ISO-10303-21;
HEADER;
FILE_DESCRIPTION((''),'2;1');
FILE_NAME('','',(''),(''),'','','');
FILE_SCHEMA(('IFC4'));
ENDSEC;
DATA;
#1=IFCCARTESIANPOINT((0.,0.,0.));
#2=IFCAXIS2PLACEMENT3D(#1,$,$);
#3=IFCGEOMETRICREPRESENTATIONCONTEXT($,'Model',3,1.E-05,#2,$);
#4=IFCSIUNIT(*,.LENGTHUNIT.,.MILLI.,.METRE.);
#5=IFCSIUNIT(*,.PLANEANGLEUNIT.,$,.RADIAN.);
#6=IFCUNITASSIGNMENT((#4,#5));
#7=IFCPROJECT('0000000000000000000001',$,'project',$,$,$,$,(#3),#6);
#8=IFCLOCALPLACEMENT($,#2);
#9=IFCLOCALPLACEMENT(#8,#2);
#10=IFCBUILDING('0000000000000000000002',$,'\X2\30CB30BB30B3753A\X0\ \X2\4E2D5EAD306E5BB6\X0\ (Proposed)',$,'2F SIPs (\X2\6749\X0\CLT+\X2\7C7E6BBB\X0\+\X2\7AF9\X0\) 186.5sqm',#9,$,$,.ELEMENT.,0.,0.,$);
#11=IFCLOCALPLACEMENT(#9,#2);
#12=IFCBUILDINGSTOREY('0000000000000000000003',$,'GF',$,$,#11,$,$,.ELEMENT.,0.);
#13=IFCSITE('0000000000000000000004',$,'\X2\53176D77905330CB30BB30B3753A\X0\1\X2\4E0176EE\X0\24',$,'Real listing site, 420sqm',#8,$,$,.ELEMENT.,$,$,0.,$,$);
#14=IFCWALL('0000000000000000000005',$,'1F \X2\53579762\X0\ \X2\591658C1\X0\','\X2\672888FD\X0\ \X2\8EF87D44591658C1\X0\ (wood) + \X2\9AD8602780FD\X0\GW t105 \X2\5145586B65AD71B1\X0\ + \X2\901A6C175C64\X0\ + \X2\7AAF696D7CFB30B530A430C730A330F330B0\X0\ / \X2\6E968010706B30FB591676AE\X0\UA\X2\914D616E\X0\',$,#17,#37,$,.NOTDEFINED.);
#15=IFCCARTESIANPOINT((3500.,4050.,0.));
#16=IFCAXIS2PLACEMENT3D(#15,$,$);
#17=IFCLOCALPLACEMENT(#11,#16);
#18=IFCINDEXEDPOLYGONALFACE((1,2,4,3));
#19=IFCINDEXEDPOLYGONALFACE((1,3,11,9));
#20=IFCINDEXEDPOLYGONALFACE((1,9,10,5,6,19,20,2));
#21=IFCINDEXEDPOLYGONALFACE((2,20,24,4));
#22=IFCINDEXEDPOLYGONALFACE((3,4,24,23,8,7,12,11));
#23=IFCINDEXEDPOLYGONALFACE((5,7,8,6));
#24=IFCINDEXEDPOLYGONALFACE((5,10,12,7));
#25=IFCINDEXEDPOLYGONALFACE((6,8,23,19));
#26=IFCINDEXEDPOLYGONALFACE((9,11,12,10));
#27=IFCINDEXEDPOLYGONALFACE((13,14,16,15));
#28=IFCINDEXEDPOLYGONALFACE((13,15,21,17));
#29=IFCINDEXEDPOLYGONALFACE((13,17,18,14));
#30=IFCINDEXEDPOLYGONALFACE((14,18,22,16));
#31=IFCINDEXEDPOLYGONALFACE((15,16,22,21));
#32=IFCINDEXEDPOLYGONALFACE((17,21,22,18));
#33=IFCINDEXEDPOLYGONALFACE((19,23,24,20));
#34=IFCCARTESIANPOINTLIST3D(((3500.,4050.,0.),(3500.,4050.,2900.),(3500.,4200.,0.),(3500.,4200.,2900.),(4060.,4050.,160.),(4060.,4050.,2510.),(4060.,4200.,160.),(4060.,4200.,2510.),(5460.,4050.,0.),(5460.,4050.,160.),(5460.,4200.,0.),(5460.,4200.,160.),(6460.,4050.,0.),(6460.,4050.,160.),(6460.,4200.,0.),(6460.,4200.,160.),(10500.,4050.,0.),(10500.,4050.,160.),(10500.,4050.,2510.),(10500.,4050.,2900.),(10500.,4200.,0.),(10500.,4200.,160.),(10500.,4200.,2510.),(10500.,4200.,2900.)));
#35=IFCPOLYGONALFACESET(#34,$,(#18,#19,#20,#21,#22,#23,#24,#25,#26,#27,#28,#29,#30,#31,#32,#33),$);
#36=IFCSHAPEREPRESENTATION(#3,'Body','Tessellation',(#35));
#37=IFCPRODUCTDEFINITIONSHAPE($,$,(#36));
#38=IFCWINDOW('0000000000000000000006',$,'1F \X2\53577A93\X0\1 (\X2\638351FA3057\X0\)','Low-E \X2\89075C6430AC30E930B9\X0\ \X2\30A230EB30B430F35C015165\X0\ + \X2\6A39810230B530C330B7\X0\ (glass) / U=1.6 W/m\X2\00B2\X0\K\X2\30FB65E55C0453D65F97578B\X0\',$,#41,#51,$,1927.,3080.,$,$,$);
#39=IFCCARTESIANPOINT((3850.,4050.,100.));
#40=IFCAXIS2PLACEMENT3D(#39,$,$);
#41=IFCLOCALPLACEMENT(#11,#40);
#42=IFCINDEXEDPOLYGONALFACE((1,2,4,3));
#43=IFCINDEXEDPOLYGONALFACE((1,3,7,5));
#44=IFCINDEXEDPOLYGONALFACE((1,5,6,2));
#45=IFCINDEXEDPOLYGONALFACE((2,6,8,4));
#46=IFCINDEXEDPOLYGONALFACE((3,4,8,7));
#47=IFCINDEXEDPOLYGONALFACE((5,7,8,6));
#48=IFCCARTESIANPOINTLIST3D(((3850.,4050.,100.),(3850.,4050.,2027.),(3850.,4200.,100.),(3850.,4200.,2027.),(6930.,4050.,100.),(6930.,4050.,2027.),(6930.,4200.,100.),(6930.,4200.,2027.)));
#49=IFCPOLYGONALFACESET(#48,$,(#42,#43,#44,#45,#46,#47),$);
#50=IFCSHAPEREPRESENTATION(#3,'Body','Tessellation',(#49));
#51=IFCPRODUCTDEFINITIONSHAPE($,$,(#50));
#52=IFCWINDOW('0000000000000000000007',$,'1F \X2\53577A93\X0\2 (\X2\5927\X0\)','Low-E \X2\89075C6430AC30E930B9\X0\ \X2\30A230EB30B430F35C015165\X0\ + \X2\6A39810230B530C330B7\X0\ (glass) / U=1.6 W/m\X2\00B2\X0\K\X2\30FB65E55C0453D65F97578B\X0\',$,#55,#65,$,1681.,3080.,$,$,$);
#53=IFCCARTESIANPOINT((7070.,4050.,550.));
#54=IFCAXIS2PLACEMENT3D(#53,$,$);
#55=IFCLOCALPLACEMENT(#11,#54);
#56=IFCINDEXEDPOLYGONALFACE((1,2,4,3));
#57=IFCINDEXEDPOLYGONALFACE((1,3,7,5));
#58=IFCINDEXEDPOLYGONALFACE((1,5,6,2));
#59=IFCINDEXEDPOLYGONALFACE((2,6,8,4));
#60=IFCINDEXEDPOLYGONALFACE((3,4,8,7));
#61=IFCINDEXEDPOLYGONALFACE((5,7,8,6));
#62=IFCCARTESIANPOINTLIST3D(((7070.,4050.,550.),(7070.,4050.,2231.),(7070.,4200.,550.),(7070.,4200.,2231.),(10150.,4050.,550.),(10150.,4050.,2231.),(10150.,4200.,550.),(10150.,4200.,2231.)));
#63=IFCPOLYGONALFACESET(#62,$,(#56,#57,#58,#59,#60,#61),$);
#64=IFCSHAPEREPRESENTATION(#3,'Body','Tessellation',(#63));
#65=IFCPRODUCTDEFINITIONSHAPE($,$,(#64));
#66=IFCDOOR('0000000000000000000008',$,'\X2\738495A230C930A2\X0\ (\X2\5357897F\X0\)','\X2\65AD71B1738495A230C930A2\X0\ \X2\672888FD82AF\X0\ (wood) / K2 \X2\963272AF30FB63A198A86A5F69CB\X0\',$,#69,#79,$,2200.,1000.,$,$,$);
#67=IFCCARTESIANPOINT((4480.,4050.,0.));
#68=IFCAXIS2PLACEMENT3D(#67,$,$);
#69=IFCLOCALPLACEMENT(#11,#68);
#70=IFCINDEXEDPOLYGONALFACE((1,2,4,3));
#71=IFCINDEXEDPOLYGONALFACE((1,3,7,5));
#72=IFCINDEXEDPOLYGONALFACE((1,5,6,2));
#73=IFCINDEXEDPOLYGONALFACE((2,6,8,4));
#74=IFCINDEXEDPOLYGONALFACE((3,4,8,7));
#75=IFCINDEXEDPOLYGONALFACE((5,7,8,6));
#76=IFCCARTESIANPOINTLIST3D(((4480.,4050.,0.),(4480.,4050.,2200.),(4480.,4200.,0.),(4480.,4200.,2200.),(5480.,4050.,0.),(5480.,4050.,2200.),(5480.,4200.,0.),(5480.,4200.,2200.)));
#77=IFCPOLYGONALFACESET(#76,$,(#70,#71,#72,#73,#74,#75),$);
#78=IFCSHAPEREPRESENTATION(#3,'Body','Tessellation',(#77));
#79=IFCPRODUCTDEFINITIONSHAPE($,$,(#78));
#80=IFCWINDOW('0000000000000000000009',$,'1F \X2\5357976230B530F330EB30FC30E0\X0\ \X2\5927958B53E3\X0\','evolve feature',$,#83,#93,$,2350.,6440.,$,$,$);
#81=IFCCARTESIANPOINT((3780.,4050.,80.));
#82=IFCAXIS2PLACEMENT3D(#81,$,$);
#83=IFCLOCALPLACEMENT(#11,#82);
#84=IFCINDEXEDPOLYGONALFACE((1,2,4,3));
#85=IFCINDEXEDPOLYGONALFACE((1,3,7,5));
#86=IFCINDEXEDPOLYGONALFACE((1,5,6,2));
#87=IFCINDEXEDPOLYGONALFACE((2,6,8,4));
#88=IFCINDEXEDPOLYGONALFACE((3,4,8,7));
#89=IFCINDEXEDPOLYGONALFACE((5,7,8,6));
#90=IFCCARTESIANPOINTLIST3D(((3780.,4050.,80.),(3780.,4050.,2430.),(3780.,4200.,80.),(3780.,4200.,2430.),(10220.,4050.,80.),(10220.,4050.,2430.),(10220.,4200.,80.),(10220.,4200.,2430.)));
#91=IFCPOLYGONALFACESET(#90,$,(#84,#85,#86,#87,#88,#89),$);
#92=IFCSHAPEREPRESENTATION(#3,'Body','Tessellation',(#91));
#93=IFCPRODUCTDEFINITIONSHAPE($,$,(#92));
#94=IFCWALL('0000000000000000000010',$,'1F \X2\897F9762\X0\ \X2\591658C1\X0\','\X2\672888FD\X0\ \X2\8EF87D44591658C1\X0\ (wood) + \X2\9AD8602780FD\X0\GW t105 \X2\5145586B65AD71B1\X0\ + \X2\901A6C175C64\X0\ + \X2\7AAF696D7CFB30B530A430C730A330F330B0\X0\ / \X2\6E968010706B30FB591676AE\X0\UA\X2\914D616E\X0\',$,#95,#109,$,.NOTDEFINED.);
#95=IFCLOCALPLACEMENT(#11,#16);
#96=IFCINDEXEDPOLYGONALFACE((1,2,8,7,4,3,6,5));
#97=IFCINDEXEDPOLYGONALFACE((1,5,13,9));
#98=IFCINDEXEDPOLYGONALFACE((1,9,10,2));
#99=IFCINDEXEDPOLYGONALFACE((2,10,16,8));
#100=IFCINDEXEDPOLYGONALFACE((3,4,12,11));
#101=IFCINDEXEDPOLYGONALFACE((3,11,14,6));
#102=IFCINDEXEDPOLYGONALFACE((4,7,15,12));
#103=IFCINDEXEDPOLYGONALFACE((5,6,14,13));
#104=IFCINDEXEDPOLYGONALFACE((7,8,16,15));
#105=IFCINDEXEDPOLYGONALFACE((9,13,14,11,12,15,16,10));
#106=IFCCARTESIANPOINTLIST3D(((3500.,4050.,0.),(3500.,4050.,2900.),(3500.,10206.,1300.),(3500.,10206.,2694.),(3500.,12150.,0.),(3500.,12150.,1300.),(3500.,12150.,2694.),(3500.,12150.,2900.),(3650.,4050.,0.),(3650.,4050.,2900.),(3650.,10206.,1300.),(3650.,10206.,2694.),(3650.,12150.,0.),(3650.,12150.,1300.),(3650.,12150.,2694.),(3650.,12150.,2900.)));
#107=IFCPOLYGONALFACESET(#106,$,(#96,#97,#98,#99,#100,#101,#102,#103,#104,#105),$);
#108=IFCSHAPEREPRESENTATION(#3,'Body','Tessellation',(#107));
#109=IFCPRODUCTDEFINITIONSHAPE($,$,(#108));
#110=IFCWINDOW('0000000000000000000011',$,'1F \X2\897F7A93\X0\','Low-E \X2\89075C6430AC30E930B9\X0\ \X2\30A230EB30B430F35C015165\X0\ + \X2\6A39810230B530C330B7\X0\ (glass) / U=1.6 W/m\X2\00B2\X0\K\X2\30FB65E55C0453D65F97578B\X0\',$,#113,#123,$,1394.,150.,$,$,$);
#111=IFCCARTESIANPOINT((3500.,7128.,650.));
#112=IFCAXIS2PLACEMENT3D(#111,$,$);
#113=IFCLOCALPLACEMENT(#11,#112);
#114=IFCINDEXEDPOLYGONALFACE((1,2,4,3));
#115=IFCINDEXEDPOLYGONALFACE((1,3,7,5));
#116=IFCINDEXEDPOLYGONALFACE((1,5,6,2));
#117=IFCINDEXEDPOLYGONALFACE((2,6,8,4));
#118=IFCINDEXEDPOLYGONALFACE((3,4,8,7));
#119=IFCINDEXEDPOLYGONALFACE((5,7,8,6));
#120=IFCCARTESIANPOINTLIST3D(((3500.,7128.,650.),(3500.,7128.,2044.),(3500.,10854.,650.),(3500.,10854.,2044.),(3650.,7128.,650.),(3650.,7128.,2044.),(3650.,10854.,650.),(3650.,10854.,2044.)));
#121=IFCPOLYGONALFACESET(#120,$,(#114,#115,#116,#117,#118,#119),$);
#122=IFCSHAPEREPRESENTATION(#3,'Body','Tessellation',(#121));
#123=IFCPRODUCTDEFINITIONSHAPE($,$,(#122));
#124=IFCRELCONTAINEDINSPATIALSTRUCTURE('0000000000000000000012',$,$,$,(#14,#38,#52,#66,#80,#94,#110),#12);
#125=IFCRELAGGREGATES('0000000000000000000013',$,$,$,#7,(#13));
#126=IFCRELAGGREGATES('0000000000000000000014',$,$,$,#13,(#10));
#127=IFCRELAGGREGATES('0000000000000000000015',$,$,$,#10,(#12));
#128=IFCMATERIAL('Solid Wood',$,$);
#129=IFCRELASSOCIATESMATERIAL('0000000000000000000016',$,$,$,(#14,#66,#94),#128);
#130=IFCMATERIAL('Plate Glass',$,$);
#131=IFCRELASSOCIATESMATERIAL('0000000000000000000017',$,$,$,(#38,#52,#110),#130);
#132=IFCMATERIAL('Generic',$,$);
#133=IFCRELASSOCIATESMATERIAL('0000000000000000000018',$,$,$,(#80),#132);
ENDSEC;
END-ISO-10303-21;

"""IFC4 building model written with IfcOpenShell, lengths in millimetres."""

from ifc_helpers import new_model, si_unit, frame, frame_2d, origin, place, context, project, spatial, rectangle, extrude, material, element, fill, save


model = new_model("IFC4")

# Units and contexts
model_context = context("Model", 3, precision=1e-05, world=origin())
ifc_project = project(units=[si_unit("LENGTHUNIT", "METRE", prefix="MILLI"), si_unit("PLANEANGLEUNIT", "RADIAN")], contexts=[model_context])

# Site, building, storey
site_placement = place(None, origin())
site = spatial("IfcSite", under=ifc_project, at=site_placement, Name="北海道ニセコ町1丁目24", ObjectType="Real listing site, 420sqm", CompositionType="ELEMENT", RefElevation=0.0)
building_placement = place(site_placement, origin())
building = spatial("IfcBuilding", under=site, at=building_placement, Name="ニセコ町 中庭の家 (Proposed)", ObjectType="2F SIPs (杉CLT+籾殻+竹) 186.5sqm", CompositionType="ELEMENT", ElevationOfRefHeight=0.0, ElevationOfTerrain=0.0)
storey_placement = place(building_placement, origin())
storey = spatial("IfcBuildingStorey", under=building, at=storey_placement, Name="GF", CompositionType="ELEMENT", Elevation=0.0)

# Shared definitions
ifc_material_1 = material(Name="Solid Wood")
ifc_material_2 = material(Name="Generic")

# Wall, openings, windows, door
wall_1_placement = place(storey_placement, frame((3500.0, 4050.0, 0.0)))
wall_1 = element("IfcWall", 1, at=wall_1_placement, inside=storey, material=ifc_material_1, Name="1F 南面 外壁", Description="木製 軸組外壁 (wood) + 高性能GW t105 充填断熱 + 通気層 + 窯業系サイディング / 準耐火・外皮UA配慮", PredefinedType="NOTDEFINED", context=model_context, shape_type="SweptSolid", body=[
    extrude(rectangle(XDim=7000.0, YDim=150.0, at=frame_2d((3500.0, 75.0))), frame((3500.0, 4050.0, 0.0)), (0.0, 0.0, 1.0), 2900.0),
])
opening_1_placement = place(storey_placement, frame((3850.0, 4050.0, 100.0)))
opening_1 = element("IfcOpeningElement", 2, at=opening_1_placement, cuts=wall_1, PredefinedType="NOTDEFINED", context=model_context, shape_type="SweptSolid", body=[
    extrude(rectangle(XDim=3080.0, YDim=150.0, at=frame_2d((1540.0, 75.0))), frame((3850.0, 4050.0, 100.0)), (0.0, 0.0, 1.0), 1927.0),
])
opening_2_placement = place(storey_placement, frame((7070.0, 4050.0, 550.0)))
opening_2 = element("IfcOpeningElement", 3, at=opening_2_placement, cuts=wall_1, PredefinedType="NOTDEFINED", context=model_context, shape_type="SweptSolid", body=[
    extrude(rectangle(XDim=3080.0, YDim=150.0, at=frame_2d((1540.0, 75.0))), frame((7070.0, 4050.0, 550.0)), (0.0, 0.0, 1.0), 1681.0),
])
opening_3_placement = place(storey_placement, frame((4480.0, 4050.0, 0.0)))
opening_3 = element("IfcOpeningElement", 4, at=opening_3_placement, cuts=wall_1, PredefinedType="NOTDEFINED", context=model_context, shape_type="SweptSolid", body=[
    extrude(rectangle(XDim=1000.0, YDim=150.0, at=frame_2d((500.0, 75.0))), frame((4480.0, 4050.0, 0.0)), (0.0, 0.0, 1.0), 2200.0),
])
opening_4_placement = place(storey_placement, frame((3780.0, 4050.0, 80.0)))
opening_4 = element("IfcOpeningElement", 5, at=opening_4_placement, cuts=wall_1, PredefinedType="NOTDEFINED", context=model_context, shape_type="SweptSolid", body=[
    extrude(rectangle(XDim=6440.0, YDim=150.0, at=frame_2d((3220.0, 75.0))), frame((3780.0, 4050.0, 80.0)), (0.0, 0.0, 1.0), 2350.0),
])
ifc_material_3 = material(Name="Plate Glass")
window_1_placement = place(storey_placement, frame((3850.0, 4050.0, 100.0)))
window_1 = element("IfcWindow", 6, at=window_1_placement, inside=storey, material=ifc_material_3, Name="1F 南窓1 (掃出し)", Description="Low-E 複層ガラス アルゴン封入 + 樹脂サッシ (glass) / U=1.6 W/m²K・日射取得型", OverallHeight=1927.0, OverallWidth=3080.0, context=model_context, shape_type="SweptSolid", body=[
    extrude(rectangle(XDim=3080.0, YDim=150.0, at=frame_2d((1540.0, 75.0))), frame((3850.0, 4050.0, 100.0)), (0.0, 0.0, 1.0), 1927.0),
])
fill(opening_1, window_1)
window_2_placement = place(storey_placement, frame((7070.0, 4050.0, 550.0)))
window_2 = element("IfcWindow", 7, at=window_2_placement, inside=storey, material=ifc_material_3, Name="1F 南窓2 (大)", Description="Low-E 複層ガラス アルゴン封入 + 樹脂サッシ (glass) / U=1.6 W/m²K・日射取得型", OverallHeight=1681.0, OverallWidth=3080.0, context=model_context, shape_type="SweptSolid", body=[
    extrude(rectangle(XDim=3080.0, YDim=150.0, at=frame_2d((1540.0, 75.0))), frame((7070.0, 4050.0, 550.0)), (0.0, 0.0, 1.0), 1681.0),
])
fill(opening_2, window_2)
door_placement = place(storey_placement, frame((4480.0, 4050.0, 0.0)))
door = element("IfcDoor", 8, at=door_placement, inside=storey, material=ifc_material_1, Name="玄関ドア (南西)", Description="断熱玄関ドア 木製芯 (wood) / K2 防犯・採風機構", OverallHeight=2200.0, OverallWidth=1000.0, context=model_context, shape_type="SweptSolid", body=[
    extrude(rectangle(XDim=1000.0, YDim=150.0, at=frame_2d((500.0, 75.0))), frame((4480.0, 4050.0, 0.0)), (0.0, 0.0, 1.0), 2200.0),
])
fill(opening_3, door)
window_3_placement = place(storey_placement, frame((3780.0, 4050.0, 80.0)))
window_3 = element("IfcWindow", 9, at=window_3_placement, inside=storey, material=ifc_material_2, Name="1F 南面サンルーム 大開口", Description="evolve feature", OverallHeight=2350.0, OverallWidth=6440.0, context=model_context, shape_type="SweptSolid", body=[
    extrude(rectangle(XDim=6440.0, YDim=150.0, at=frame_2d((3220.0, 75.0))), frame((3780.0, 4050.0, 80.0)), (0.0, 0.0, 1.0), 2350.0),
])
fill(opening_4, window_3)

# Wall, opening, window
wall_2_placement = place(storey_placement, frame((3500.0, 4050.0, 0.0)))
wall_2 = element("IfcWall", 10, at=wall_2_placement, inside=storey, material=ifc_material_1, Name="1F 西面 外壁", Description="木製 軸組外壁 (wood) + 高性能GW t105 充填断熱 + 通気層 + 窯業系サイディング / 準耐火・外皮UA配慮", PredefinedType="NOTDEFINED", context=model_context, shape_type="SweptSolid", body=[
    extrude(rectangle(XDim=150.0, YDim=8100.0, at=frame_2d((75.0, 4050.0))), frame((3500.0, 4050.0, 0.0)), (0.0, 0.0, 1.0), 2900.0),
])
opening_5_placement = place(storey_placement, frame((3500.0, 7128.0, 650.0)))
opening_5 = element("IfcOpeningElement", 11, at=opening_5_placement, cuts=wall_2, PredefinedType="NOTDEFINED", context=model_context, shape_type="SweptSolid", body=[
    extrude(rectangle(XDim=150.0, YDim=3726.0, at=frame_2d((75.0, 1863.0))), frame((3500.0, 7128.0, 650.0)), (0.0, 0.0, 1.0), 1394.0),
])
window_4_placement = place(storey_placement, frame((3500.0, 7128.0, 650.0)))
window_4 = element("IfcWindow", 12, at=window_4_placement, inside=storey, material=ifc_material_3, Name="1F 西窓", Description="Low-E 複層ガラス アルゴン封入 + 樹脂サッシ (glass) / U=1.6 W/m²K・日射取得型", OverallHeight=1394.0, OverallWidth=150.0, context=model_context, shape_type="SweptSolid", body=[
    extrude(rectangle(XDim=150.0, YDim=3726.0, at=frame_2d((75.0, 1863.0))), frame((3500.0, 7128.0, 650.0)), (0.0, 0.0, 1.0), 1394.0),
])
fill(opening_5, window_4)

save(model, "model.ifc")
